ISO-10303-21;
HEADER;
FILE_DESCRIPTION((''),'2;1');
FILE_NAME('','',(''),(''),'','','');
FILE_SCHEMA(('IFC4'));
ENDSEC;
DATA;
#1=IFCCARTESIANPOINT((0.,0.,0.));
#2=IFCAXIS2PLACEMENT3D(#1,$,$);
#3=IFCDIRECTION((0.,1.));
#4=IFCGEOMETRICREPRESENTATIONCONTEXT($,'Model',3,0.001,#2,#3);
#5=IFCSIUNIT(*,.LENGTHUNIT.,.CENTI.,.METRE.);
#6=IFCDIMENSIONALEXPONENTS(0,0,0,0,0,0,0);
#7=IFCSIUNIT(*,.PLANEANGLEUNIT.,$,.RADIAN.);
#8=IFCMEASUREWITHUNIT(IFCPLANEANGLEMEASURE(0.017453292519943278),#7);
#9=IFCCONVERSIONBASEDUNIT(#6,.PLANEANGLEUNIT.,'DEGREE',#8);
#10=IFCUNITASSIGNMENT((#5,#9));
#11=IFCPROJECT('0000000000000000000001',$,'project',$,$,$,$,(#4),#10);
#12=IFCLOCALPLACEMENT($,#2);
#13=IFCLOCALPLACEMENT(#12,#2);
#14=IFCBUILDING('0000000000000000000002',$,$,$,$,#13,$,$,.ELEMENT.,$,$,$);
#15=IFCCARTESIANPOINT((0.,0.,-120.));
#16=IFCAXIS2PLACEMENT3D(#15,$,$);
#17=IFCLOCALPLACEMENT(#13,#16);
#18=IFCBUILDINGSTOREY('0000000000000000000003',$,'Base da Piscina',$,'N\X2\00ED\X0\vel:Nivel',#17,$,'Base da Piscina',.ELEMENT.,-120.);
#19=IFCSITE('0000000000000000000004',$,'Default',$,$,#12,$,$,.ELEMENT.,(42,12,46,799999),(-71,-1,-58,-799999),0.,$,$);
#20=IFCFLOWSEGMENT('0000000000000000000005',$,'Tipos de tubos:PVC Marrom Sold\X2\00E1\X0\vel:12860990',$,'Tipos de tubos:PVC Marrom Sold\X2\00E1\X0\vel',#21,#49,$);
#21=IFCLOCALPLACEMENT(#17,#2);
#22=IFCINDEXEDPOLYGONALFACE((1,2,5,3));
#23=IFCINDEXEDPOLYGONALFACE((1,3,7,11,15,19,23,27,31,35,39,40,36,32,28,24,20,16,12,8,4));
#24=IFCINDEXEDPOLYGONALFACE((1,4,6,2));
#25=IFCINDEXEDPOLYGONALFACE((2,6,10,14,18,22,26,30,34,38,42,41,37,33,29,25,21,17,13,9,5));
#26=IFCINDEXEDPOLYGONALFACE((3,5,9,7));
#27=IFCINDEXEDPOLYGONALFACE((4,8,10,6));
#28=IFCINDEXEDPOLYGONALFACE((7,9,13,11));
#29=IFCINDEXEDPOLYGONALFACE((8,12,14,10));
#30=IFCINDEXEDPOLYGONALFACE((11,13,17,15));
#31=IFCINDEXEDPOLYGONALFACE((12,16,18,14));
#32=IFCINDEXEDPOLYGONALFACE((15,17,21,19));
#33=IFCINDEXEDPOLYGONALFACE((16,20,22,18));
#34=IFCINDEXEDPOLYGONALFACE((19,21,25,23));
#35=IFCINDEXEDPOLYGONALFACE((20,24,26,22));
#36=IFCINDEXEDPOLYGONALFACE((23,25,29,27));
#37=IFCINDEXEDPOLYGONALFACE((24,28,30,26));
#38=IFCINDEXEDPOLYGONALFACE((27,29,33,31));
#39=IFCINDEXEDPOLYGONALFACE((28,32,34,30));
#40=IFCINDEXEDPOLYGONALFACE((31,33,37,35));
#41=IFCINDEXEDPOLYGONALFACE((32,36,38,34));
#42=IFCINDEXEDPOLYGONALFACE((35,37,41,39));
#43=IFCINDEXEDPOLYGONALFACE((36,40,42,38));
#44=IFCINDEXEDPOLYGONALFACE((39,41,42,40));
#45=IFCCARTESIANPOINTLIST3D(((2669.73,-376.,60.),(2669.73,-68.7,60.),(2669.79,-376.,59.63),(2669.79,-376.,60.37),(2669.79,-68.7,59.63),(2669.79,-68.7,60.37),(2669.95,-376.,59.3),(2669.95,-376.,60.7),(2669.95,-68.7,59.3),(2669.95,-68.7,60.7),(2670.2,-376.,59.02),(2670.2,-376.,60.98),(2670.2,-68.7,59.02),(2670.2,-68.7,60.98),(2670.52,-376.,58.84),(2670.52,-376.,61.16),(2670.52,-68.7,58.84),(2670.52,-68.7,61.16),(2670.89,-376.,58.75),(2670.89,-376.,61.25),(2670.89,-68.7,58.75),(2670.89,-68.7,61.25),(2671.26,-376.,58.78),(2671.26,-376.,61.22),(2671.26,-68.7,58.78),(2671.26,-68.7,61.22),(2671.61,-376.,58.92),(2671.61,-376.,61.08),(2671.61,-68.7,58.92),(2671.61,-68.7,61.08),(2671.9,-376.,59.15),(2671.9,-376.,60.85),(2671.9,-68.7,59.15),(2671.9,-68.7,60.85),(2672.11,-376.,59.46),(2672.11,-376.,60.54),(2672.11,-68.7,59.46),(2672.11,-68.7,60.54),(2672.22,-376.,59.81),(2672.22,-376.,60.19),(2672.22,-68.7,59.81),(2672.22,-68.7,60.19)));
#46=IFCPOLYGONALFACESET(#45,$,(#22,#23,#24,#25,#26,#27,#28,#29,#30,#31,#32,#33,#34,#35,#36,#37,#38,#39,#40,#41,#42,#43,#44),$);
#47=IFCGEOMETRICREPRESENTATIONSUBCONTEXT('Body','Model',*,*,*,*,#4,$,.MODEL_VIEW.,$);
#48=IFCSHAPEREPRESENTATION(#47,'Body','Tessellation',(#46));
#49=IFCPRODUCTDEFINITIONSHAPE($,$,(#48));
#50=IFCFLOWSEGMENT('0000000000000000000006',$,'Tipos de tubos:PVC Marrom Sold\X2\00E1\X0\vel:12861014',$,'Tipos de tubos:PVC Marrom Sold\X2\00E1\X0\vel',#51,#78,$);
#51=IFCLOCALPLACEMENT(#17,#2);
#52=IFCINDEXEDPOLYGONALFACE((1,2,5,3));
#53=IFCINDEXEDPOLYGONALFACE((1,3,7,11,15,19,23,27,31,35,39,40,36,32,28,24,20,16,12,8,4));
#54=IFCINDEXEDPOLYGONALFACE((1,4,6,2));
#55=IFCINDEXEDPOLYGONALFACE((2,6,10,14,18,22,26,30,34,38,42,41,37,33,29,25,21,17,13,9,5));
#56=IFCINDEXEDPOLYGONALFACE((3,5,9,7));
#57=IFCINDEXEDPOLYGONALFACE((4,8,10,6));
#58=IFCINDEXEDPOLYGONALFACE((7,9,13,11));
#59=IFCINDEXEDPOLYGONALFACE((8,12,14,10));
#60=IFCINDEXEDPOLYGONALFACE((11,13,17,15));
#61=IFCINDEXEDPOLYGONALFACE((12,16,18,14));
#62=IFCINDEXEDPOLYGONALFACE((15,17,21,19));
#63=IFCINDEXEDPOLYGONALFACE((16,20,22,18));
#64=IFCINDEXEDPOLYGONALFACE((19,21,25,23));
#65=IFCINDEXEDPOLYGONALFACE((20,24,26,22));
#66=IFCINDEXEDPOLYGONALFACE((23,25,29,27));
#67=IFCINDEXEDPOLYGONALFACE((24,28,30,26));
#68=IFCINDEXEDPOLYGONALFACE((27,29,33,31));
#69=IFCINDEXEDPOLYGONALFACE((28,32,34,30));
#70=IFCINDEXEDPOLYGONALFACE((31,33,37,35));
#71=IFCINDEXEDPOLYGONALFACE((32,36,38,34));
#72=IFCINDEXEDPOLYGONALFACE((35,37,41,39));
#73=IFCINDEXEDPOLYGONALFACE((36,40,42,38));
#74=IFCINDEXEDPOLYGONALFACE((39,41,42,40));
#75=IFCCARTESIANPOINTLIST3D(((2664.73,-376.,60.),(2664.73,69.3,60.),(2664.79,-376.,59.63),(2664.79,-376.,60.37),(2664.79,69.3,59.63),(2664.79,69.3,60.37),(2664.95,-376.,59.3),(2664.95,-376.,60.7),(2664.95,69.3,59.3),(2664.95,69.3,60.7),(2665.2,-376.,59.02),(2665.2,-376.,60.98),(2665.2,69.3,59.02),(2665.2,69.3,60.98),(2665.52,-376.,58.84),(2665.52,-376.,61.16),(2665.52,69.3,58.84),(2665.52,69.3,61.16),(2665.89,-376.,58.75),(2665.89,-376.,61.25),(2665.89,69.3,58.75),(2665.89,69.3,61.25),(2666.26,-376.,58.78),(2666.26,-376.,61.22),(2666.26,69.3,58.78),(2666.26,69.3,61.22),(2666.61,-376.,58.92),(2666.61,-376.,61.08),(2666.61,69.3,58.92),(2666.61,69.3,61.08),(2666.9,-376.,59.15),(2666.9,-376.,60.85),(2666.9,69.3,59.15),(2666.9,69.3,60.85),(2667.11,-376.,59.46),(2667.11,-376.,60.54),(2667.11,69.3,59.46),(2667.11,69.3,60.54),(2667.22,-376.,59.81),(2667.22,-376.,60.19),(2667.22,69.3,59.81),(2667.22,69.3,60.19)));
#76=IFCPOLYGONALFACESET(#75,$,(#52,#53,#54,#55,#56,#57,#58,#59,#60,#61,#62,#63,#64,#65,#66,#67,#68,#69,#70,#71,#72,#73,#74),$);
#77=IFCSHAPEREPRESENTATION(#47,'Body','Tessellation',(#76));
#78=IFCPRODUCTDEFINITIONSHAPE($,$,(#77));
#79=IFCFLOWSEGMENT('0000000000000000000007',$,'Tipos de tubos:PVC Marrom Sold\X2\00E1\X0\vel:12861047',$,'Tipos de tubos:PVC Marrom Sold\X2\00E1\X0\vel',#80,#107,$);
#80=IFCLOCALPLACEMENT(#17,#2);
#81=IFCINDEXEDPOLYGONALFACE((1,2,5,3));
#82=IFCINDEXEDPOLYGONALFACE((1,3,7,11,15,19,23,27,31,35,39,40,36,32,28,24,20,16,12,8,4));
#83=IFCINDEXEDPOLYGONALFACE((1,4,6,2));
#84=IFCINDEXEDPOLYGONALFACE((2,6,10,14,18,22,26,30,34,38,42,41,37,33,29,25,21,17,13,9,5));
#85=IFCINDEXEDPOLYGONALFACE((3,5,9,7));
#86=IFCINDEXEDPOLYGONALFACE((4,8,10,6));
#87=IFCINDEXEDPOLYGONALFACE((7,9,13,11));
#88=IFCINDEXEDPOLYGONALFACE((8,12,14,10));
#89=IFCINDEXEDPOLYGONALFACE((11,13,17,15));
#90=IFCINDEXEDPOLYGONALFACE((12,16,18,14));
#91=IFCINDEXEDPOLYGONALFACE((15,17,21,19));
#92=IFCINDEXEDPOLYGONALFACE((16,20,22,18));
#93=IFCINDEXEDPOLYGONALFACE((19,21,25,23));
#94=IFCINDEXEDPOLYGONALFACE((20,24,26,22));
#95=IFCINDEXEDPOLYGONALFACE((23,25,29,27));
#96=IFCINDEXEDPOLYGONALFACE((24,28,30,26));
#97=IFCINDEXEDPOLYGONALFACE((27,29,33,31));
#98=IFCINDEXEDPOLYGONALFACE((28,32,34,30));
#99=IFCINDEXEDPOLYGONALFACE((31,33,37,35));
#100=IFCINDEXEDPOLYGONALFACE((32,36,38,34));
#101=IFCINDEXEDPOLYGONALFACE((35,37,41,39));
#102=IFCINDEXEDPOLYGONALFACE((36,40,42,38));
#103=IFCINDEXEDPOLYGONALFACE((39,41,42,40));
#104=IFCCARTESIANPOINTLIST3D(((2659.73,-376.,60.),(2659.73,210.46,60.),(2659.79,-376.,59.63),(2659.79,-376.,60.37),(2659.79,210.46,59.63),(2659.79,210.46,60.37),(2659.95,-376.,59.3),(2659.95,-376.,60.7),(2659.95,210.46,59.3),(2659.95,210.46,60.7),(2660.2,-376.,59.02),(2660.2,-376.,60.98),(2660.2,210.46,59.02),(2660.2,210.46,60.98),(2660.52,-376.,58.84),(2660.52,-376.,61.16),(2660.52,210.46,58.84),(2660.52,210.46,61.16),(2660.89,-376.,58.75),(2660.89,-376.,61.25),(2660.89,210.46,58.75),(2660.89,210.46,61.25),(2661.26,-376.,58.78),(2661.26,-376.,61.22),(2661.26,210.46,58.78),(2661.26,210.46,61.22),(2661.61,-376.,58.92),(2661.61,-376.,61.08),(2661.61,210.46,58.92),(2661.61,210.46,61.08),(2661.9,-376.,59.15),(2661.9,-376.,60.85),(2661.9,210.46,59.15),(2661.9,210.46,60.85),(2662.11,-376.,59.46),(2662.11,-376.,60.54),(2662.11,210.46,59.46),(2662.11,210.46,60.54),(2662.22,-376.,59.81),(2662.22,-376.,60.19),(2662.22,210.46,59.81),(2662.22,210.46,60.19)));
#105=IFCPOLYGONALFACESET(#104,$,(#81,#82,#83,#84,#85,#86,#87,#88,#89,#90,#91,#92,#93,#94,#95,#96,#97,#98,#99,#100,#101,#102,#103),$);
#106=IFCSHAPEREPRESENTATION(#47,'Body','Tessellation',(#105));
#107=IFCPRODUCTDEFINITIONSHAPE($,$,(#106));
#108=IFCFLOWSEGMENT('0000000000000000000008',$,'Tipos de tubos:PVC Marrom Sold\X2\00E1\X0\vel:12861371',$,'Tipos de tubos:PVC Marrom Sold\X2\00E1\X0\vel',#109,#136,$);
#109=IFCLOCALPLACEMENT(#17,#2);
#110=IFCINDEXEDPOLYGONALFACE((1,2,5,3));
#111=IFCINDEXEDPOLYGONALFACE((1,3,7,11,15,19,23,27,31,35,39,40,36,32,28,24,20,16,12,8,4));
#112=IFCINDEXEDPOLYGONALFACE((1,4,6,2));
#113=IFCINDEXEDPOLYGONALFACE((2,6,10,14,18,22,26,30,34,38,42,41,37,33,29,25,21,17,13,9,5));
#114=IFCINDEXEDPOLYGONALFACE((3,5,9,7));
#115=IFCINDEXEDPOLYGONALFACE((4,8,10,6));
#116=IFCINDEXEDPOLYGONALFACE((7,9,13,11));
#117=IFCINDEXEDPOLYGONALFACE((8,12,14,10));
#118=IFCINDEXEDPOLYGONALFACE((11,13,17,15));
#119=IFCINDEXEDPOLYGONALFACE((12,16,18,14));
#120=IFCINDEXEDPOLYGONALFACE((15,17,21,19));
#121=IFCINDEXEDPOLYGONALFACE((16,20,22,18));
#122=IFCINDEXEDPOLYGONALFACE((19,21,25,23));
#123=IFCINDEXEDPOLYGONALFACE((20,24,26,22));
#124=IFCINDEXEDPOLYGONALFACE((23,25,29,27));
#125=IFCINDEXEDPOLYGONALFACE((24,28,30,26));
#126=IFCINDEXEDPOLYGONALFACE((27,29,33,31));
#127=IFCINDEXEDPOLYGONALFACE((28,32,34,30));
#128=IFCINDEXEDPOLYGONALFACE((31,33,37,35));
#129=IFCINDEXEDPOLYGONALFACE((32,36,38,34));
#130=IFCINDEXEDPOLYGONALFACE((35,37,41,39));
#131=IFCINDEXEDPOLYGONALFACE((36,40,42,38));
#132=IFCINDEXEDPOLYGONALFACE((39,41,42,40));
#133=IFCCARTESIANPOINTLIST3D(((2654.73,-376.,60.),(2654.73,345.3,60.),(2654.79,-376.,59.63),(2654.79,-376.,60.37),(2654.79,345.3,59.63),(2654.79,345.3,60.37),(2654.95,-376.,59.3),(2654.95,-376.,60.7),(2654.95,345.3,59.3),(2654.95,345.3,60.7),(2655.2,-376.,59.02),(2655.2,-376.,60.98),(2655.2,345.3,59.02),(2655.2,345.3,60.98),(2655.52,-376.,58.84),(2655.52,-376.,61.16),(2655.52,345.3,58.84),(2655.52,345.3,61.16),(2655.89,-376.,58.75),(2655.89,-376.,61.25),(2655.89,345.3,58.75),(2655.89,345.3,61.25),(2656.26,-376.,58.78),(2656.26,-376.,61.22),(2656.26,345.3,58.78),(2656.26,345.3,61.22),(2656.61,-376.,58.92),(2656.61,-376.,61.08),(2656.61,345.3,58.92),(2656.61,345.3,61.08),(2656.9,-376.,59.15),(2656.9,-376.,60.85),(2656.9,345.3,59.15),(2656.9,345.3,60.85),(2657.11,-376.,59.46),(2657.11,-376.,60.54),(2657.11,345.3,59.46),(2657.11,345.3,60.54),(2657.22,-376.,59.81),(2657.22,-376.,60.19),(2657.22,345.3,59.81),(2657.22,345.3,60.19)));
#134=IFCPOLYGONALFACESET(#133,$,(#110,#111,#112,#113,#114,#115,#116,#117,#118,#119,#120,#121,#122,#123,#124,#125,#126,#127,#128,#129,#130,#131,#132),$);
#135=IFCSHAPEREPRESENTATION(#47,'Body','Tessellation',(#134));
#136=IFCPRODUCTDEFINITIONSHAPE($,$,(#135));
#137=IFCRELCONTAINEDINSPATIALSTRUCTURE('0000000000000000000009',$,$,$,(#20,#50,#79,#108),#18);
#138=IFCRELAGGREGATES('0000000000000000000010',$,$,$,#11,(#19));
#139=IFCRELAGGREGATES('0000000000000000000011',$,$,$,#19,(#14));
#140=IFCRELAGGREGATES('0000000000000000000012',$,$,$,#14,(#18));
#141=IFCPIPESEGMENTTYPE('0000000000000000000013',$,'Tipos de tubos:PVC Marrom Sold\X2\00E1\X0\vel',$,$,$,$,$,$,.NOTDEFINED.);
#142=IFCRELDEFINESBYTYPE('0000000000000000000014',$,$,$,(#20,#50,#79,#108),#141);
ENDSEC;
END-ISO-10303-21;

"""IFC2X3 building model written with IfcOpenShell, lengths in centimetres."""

from ifc_helpers import new_model, entity, si_unit, converted_unit, direction, frame, frame_2d, origin, origin_2d_with_axis, place, context, subcontext, project, spatial, circle, extrude, type_object, element, save


model = new_model("IFC2X3")

# Units and contexts
model_context = context("Model", 3, precision=0.001, world=origin(), true_north=direction((0.0, 1.0)))
body_context = subcontext(model_context, "Body", "Model", "MODEL_VIEW")
ifc_project = project(units=[si_unit("LENGTHUNIT", "METRE", prefix="CENTI"), converted_unit("PLANEANGLEUNIT", "DEGREE", entity("IfcPlaneAngleMeasure", 0.017453292519943278), si_unit("PLANEANGLEUNIT", "RADIAN"), dimensions=[0, 0, 0, 0, 0, 0, 0])], contexts=[model_context])

# Site, building, storey
site_placement = place(None, origin())
site = spatial("IfcSite", under=ifc_project, at=site_placement, Name="Default", CompositionType="ELEMENT", RefLatitude=(42, 12, 46, 799999), RefLongitude=(-71, -1, -58, -799999), RefElevation=0.0)
building_placement = place(site_placement, origin())
building = spatial("IfcBuilding", under=site, at=building_placement, CompositionType="ELEMENT")
storey_placement = place(building_placement, frame((0.0, 0.0, -120.0)))
storey = spatial("IfcBuildingStorey", under=building, at=storey_placement, Name="Base da Piscina", ObjectType="Nível:Nivel", LongName="Base da Piscina", CompositionType="ELEMENT", Elevation=-120.0)

# Flow segments
pipe_segment_type = type_object("IfcPipeSegmentType", Name="Tipos de tubos:PVC Marrom Soldável", PredefinedType="NOTDEFINED")
flow_segment_1_placement = place(storey_placement, origin())
element("IfcFlowSegment", 1, at=flow_segment_1_placement, inside=storey, type_object=pipe_segment_type, Name="Tipos de tubos:PVC Marrom Soldável:12860990", ObjectType="Tipos de tubos:PVC Marrom Soldável", context=body_context, shape_type="SweptSolid", body=[
    extrude(circle(Radius=1.25, at=frame_2d((0.0, 0.0), x_axis=(1.0, 0.0))), frame((2670.98, -376.0, 60.0), z_axis=(0.0, 1.0, 0.0), x_axis=(-1.0, 0.0, 0.0)), (0.0, 0.0, 1.0), 307.3),
])
flow_segment_2_placement = place(storey_placement, origin())
element("IfcFlowSegment", 2, at=flow_segment_2_placement, inside=storey, type_object=pipe_segment_type, Name="Tipos de tubos:PVC Marrom Soldável:12861014", ObjectType="Tipos de tubos:PVC Marrom Soldável", context=body_context, shape_type="SweptSolid", body=[
    extrude(circle(Radius=1.25, at=frame_2d((0.0, 0.0), x_axis=(1.0, 0.0))), frame((2665.98, -376.0, 60.0), z_axis=(0.0, 1.0, 0.0), x_axis=(-1.0, 0.0, 0.0)), (0.0, 0.0, 1.0), 445.3),
])
flow_segment_3_placement = place(storey_placement, origin())
element("IfcFlowSegment", 3, at=flow_segment_3_placement, inside=storey, type_object=pipe_segment_type, Name="Tipos de tubos:PVC Marrom Soldável:12861047", ObjectType="Tipos de tubos:PVC Marrom Soldável", context=body_context, shape_type="SweptSolid", body=[
    extrude(circle(Radius=1.25, at=origin_2d_with_axis()), frame((2660.98, -376.0, 60.0), z_axis=(0.0, 1.0, 0.0), x_axis=(-1.0, 0.0, 0.0)), (0.0, 0.0, 1.0), 586.46),
])
flow_segment_4_placement = place(storey_placement, origin())
element("IfcFlowSegment", 4, at=flow_segment_4_placement, inside=storey, type_object=pipe_segment_type, Name="Tipos de tubos:PVC Marrom Soldável:12861371", ObjectType="Tipos de tubos:PVC Marrom Soldável", context=body_context, shape_type="SweptSolid", body=[
    extrude(circle(Radius=1.25, at=frame_2d((0.0, 0.0), x_axis=(1.0, 0.0))), frame((2655.98, -376.0, 60.0), z_axis=(0.0, 1.0, 0.0), x_axis=(-1.0, 0.0, 0.0)), (0.0, 0.0, 1.0), 721.3),
])

save(model, "model.ifc")
